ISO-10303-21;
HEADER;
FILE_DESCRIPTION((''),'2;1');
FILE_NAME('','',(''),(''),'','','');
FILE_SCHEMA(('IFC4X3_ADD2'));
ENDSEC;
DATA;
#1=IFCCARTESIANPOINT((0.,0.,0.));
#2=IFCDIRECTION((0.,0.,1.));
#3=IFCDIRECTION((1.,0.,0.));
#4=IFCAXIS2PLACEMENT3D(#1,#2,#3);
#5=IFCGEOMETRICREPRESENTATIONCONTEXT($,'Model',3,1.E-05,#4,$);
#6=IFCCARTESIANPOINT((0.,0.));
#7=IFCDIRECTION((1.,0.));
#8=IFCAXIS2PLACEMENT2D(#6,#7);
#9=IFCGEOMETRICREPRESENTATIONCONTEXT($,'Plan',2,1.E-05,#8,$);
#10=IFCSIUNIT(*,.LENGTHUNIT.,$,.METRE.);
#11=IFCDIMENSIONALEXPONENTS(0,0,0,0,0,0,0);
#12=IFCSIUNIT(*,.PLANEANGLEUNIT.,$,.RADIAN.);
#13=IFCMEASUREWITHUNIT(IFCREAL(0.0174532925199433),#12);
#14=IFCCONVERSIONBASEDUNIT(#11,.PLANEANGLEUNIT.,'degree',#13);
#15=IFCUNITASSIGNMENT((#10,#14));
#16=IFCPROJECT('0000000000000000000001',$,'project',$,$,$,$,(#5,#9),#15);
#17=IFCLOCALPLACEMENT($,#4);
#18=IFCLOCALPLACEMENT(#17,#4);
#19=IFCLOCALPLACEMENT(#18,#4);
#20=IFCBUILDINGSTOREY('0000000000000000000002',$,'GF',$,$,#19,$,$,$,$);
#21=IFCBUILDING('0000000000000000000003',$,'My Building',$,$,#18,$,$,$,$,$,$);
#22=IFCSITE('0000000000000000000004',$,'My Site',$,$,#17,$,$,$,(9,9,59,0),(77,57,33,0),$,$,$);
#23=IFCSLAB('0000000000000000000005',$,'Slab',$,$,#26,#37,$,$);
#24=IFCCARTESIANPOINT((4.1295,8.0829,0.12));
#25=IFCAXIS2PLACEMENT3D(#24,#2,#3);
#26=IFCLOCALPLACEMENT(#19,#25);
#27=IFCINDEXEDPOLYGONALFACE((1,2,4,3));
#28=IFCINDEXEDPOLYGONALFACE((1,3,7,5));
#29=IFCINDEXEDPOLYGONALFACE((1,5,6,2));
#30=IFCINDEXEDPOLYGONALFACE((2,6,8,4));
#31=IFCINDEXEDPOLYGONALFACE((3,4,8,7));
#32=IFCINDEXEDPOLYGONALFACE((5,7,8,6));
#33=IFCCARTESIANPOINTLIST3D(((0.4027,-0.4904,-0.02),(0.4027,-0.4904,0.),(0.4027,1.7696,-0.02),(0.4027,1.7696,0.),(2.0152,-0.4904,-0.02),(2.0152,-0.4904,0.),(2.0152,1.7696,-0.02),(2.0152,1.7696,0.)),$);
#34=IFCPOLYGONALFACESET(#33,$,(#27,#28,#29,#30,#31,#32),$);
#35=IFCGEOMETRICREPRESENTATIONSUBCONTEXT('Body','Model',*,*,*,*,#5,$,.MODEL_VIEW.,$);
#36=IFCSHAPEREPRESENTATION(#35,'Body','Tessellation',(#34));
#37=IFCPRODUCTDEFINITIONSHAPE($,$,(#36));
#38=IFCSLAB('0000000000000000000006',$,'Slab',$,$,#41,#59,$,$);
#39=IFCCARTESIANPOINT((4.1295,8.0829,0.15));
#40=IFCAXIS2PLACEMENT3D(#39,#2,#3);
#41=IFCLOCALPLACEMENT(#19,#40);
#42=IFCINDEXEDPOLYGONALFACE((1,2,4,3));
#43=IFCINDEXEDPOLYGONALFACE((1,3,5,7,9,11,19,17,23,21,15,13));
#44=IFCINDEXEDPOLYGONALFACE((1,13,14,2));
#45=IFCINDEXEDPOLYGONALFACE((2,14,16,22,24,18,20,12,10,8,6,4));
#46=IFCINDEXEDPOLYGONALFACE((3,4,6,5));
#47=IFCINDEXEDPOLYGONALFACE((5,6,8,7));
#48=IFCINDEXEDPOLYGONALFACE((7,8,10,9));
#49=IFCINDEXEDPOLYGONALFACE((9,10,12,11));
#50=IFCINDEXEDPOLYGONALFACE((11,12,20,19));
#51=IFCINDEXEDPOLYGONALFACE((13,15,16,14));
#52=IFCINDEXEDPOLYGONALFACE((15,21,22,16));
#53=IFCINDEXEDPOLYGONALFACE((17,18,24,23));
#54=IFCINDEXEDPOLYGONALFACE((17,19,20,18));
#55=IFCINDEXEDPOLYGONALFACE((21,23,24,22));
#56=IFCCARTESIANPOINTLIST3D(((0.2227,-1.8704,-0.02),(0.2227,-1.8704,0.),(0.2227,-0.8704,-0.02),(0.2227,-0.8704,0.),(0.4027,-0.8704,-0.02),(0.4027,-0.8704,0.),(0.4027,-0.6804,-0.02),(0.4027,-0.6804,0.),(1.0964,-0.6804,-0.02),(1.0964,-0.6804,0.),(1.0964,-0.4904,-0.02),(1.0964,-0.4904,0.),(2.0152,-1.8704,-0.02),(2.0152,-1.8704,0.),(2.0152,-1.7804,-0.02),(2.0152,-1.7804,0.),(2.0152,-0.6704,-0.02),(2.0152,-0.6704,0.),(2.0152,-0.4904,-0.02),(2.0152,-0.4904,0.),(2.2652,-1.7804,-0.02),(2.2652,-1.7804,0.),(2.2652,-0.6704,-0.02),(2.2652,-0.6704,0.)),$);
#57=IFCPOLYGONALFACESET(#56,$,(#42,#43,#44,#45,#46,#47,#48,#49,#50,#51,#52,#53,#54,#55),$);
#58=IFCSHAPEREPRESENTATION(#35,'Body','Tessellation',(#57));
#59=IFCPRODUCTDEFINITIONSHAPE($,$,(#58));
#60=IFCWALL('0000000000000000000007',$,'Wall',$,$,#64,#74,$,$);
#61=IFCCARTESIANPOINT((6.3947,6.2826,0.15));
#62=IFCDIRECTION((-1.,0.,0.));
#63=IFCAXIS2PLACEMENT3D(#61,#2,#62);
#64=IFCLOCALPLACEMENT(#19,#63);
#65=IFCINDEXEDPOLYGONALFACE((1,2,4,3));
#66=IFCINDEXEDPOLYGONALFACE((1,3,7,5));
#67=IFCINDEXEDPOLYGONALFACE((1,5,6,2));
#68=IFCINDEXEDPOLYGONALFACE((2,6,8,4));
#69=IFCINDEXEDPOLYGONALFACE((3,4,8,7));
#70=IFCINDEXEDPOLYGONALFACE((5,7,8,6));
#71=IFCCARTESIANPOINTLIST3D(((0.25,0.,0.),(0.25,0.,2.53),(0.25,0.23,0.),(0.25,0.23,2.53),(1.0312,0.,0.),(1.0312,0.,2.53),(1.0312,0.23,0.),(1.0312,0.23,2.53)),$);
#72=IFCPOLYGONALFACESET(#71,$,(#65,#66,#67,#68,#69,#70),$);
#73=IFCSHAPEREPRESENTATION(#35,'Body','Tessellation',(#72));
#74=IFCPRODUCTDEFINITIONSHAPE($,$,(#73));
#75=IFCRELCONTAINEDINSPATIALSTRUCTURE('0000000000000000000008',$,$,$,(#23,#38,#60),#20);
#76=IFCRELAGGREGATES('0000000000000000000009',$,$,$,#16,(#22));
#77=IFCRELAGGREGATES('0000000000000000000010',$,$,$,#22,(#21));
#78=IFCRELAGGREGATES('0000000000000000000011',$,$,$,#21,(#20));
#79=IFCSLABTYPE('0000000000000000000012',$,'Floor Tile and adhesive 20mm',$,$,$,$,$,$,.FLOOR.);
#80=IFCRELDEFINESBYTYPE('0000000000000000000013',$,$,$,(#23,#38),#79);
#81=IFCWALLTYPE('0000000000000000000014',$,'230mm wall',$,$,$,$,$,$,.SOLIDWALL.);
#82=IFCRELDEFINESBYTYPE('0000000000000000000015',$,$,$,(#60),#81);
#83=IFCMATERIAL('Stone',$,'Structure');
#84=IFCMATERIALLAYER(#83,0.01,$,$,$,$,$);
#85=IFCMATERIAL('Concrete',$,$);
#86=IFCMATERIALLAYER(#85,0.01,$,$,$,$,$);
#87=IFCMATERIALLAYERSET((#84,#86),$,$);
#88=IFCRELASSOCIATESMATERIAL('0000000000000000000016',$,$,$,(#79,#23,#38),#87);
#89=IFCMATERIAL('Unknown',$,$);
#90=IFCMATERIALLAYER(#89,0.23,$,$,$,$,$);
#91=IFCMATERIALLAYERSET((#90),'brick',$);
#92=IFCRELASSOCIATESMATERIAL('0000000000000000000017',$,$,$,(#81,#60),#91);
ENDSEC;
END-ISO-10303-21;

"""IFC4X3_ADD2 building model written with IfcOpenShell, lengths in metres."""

from ifc_helpers import new_model, entity, si_unit, converted_unit, frame, origin_with_axes, origin_2d_with_axis, place, context, subcontext, project, spatial, line, indexed_curve, outline, extrude, material, layer, layer_set, layer_usage, type_object, element, save


model = new_model("IFC4X3_ADD2")

# Units and contexts
model_context = context("Model", 3, precision=1e-05, world=origin_with_axes())
plan_context = context("Plan", 2, precision=1e-05, world=origin_2d_with_axis())
body_context_1 = subcontext(model_context, "Body", "Model", "MODEL_VIEW")
ifc_project = project(units=[si_unit("LENGTHUNIT", "METRE"), converted_unit("PLANEANGLEUNIT", "degree", entity("IfcReal", 0.0174532925199433), si_unit("PLANEANGLEUNIT", "RADIAN"), dimensions=[0, 0, 0, 0, 0, 0, 0])], contexts=[model_context, plan_context])

# Site, building, storey
site_placement = place(None, origin_with_axes())
site = spatial("IfcSite", under=ifc_project, at=site_placement, Name="My Site", RefLatitude=(9, 9, 59, 0), RefLongitude=(77, 57, 33, 0))
building_placement = place(site_placement, origin_with_axes())
building = spatial("IfcBuilding", under=site, at=building_placement, Name="My Building")
storey_placement = place(building_placement, origin_with_axes())
storey = spatial("IfcBuildingStorey", under=building, at=storey_placement, Name="GF")

# Slabs
ifc_material_1 = material(Name="Stone", Category="Structure")
ifc_layer_1 = layer(ifc_material_1, 0.01)
ifc_material_2 = material(Name="Concrete")
ifc_layer_2 = layer(ifc_material_2, 0.01)
ifc_layer_set_1 = layer_set([ifc_layer_1, ifc_layer_2])
ifc_layer_usage_1 = layer_usage(ifc_layer_set_1, "AXIS3", "POSITIVE", -0.02)
slab_type = type_object("IfcSlabType", Name="Floor Tile and adhesive 20mm", PredefinedType="FLOOR", material=ifc_layer_set_1)
slab_1_placement = place(storey_placement, frame((4.1295, 8.0829, 0.12), z_axis=(0.0, 0.0, 1.0), x_axis=(1.0, 0.0, 0.0)))
element("IfcSlab", 1, at=slab_1_placement, inside=storey, type_object=slab_type, material=ifc_layer_usage_1, Name="Slab", context=body_context_1, shape_type="SweptSolid", body=[
    extrude(outline(indexed_curve([(2.0152, -0.4904), (2.0152, 1.7696), (0.4027, 1.7696), (0.4027, -0.4904), (2.0152, -0.4904)])), frame((0.0, 0.0, -0.02), z_axis=(0.0, 0.0, 1.0), x_axis=(1.0, 0.0, 0.0)), (0.0, 0.0, 1.0), 0.02),
])
ifc_layer_usage_2 = layer_usage(ifc_layer_set_1, "AXIS3", "POSITIVE", -0.02)
slab_2_placement = place(storey_placement, frame((4.1295, 8.0829, 0.15), z_axis=(0.0, 0.0, 1.0), x_axis=(1.0, 0.0, 0.0)))
element("IfcSlab", 2, at=slab_2_placement, inside=storey, type_object=slab_type, material=ifc_layer_usage_2, Name="Slab", context=body_context_1, shape_type="SweptSolid", body=[
    extrude(outline(indexed_curve([(2.2652, -0.6704), (2.0152, -0.6704), (2.0152, -0.4904), (1.0964, -0.4904), (1.0964, -0.6804), (0.4027, -0.6804), (0.4027, -0.8704), (0.2227, -0.8704), (0.2227, -1.8704), (2.0152, -1.8704), (2.0152, -1.7804), (2.2652, -1.7804), (2.2652, -0.6704)])), frame((0.0, 0.0, -0.02), z_axis=(0.0, 0.0, 1.0), x_axis=(1.0, 0.0, 0.0)), (0.0, 0.0, 1.0), 0.02),
])

# Wall
ifc_material_3 = material(Name="Unknown")
ifc_layer_3 = layer(ifc_material_3, 0.23)
ifc_layer_set_2 = layer_set([ifc_layer_3], Name="brick")
ifc_layer_usage_3 = layer_usage(ifc_layer_set_2, "AXIS2", "POSITIVE", 0.0)
wall_type_1 = type_object("IfcWallType", Name="230mm wall", PredefinedType="SOLIDWALL", material=ifc_layer_set_2)
wall_1_placement = place(storey_placement, frame((6.3947, 6.2826, 0.15), z_axis=(0.0, 0.0, 1.0), x_axis=(-1.0, 0.0, 0.0)))
element("IfcWall", 3, at=wall_1_placement, inside=storey, type_object=wall_type_1, material=ifc_layer_usage_3, Name="Wall", context=body_context_1, shape_type="SweptSolid", body=[
    extrude(outline(indexed_curve([(0.25, 0.0), (0.25, 0.23), (1.0312, 0.23), (1.0312, 0.0)], segments=[line(1, 2, 3, 4, 1)])), origin_with_axes(), (0.0, 0.0, 1.0), 2.53),
])

save(model, "model.ifc")
